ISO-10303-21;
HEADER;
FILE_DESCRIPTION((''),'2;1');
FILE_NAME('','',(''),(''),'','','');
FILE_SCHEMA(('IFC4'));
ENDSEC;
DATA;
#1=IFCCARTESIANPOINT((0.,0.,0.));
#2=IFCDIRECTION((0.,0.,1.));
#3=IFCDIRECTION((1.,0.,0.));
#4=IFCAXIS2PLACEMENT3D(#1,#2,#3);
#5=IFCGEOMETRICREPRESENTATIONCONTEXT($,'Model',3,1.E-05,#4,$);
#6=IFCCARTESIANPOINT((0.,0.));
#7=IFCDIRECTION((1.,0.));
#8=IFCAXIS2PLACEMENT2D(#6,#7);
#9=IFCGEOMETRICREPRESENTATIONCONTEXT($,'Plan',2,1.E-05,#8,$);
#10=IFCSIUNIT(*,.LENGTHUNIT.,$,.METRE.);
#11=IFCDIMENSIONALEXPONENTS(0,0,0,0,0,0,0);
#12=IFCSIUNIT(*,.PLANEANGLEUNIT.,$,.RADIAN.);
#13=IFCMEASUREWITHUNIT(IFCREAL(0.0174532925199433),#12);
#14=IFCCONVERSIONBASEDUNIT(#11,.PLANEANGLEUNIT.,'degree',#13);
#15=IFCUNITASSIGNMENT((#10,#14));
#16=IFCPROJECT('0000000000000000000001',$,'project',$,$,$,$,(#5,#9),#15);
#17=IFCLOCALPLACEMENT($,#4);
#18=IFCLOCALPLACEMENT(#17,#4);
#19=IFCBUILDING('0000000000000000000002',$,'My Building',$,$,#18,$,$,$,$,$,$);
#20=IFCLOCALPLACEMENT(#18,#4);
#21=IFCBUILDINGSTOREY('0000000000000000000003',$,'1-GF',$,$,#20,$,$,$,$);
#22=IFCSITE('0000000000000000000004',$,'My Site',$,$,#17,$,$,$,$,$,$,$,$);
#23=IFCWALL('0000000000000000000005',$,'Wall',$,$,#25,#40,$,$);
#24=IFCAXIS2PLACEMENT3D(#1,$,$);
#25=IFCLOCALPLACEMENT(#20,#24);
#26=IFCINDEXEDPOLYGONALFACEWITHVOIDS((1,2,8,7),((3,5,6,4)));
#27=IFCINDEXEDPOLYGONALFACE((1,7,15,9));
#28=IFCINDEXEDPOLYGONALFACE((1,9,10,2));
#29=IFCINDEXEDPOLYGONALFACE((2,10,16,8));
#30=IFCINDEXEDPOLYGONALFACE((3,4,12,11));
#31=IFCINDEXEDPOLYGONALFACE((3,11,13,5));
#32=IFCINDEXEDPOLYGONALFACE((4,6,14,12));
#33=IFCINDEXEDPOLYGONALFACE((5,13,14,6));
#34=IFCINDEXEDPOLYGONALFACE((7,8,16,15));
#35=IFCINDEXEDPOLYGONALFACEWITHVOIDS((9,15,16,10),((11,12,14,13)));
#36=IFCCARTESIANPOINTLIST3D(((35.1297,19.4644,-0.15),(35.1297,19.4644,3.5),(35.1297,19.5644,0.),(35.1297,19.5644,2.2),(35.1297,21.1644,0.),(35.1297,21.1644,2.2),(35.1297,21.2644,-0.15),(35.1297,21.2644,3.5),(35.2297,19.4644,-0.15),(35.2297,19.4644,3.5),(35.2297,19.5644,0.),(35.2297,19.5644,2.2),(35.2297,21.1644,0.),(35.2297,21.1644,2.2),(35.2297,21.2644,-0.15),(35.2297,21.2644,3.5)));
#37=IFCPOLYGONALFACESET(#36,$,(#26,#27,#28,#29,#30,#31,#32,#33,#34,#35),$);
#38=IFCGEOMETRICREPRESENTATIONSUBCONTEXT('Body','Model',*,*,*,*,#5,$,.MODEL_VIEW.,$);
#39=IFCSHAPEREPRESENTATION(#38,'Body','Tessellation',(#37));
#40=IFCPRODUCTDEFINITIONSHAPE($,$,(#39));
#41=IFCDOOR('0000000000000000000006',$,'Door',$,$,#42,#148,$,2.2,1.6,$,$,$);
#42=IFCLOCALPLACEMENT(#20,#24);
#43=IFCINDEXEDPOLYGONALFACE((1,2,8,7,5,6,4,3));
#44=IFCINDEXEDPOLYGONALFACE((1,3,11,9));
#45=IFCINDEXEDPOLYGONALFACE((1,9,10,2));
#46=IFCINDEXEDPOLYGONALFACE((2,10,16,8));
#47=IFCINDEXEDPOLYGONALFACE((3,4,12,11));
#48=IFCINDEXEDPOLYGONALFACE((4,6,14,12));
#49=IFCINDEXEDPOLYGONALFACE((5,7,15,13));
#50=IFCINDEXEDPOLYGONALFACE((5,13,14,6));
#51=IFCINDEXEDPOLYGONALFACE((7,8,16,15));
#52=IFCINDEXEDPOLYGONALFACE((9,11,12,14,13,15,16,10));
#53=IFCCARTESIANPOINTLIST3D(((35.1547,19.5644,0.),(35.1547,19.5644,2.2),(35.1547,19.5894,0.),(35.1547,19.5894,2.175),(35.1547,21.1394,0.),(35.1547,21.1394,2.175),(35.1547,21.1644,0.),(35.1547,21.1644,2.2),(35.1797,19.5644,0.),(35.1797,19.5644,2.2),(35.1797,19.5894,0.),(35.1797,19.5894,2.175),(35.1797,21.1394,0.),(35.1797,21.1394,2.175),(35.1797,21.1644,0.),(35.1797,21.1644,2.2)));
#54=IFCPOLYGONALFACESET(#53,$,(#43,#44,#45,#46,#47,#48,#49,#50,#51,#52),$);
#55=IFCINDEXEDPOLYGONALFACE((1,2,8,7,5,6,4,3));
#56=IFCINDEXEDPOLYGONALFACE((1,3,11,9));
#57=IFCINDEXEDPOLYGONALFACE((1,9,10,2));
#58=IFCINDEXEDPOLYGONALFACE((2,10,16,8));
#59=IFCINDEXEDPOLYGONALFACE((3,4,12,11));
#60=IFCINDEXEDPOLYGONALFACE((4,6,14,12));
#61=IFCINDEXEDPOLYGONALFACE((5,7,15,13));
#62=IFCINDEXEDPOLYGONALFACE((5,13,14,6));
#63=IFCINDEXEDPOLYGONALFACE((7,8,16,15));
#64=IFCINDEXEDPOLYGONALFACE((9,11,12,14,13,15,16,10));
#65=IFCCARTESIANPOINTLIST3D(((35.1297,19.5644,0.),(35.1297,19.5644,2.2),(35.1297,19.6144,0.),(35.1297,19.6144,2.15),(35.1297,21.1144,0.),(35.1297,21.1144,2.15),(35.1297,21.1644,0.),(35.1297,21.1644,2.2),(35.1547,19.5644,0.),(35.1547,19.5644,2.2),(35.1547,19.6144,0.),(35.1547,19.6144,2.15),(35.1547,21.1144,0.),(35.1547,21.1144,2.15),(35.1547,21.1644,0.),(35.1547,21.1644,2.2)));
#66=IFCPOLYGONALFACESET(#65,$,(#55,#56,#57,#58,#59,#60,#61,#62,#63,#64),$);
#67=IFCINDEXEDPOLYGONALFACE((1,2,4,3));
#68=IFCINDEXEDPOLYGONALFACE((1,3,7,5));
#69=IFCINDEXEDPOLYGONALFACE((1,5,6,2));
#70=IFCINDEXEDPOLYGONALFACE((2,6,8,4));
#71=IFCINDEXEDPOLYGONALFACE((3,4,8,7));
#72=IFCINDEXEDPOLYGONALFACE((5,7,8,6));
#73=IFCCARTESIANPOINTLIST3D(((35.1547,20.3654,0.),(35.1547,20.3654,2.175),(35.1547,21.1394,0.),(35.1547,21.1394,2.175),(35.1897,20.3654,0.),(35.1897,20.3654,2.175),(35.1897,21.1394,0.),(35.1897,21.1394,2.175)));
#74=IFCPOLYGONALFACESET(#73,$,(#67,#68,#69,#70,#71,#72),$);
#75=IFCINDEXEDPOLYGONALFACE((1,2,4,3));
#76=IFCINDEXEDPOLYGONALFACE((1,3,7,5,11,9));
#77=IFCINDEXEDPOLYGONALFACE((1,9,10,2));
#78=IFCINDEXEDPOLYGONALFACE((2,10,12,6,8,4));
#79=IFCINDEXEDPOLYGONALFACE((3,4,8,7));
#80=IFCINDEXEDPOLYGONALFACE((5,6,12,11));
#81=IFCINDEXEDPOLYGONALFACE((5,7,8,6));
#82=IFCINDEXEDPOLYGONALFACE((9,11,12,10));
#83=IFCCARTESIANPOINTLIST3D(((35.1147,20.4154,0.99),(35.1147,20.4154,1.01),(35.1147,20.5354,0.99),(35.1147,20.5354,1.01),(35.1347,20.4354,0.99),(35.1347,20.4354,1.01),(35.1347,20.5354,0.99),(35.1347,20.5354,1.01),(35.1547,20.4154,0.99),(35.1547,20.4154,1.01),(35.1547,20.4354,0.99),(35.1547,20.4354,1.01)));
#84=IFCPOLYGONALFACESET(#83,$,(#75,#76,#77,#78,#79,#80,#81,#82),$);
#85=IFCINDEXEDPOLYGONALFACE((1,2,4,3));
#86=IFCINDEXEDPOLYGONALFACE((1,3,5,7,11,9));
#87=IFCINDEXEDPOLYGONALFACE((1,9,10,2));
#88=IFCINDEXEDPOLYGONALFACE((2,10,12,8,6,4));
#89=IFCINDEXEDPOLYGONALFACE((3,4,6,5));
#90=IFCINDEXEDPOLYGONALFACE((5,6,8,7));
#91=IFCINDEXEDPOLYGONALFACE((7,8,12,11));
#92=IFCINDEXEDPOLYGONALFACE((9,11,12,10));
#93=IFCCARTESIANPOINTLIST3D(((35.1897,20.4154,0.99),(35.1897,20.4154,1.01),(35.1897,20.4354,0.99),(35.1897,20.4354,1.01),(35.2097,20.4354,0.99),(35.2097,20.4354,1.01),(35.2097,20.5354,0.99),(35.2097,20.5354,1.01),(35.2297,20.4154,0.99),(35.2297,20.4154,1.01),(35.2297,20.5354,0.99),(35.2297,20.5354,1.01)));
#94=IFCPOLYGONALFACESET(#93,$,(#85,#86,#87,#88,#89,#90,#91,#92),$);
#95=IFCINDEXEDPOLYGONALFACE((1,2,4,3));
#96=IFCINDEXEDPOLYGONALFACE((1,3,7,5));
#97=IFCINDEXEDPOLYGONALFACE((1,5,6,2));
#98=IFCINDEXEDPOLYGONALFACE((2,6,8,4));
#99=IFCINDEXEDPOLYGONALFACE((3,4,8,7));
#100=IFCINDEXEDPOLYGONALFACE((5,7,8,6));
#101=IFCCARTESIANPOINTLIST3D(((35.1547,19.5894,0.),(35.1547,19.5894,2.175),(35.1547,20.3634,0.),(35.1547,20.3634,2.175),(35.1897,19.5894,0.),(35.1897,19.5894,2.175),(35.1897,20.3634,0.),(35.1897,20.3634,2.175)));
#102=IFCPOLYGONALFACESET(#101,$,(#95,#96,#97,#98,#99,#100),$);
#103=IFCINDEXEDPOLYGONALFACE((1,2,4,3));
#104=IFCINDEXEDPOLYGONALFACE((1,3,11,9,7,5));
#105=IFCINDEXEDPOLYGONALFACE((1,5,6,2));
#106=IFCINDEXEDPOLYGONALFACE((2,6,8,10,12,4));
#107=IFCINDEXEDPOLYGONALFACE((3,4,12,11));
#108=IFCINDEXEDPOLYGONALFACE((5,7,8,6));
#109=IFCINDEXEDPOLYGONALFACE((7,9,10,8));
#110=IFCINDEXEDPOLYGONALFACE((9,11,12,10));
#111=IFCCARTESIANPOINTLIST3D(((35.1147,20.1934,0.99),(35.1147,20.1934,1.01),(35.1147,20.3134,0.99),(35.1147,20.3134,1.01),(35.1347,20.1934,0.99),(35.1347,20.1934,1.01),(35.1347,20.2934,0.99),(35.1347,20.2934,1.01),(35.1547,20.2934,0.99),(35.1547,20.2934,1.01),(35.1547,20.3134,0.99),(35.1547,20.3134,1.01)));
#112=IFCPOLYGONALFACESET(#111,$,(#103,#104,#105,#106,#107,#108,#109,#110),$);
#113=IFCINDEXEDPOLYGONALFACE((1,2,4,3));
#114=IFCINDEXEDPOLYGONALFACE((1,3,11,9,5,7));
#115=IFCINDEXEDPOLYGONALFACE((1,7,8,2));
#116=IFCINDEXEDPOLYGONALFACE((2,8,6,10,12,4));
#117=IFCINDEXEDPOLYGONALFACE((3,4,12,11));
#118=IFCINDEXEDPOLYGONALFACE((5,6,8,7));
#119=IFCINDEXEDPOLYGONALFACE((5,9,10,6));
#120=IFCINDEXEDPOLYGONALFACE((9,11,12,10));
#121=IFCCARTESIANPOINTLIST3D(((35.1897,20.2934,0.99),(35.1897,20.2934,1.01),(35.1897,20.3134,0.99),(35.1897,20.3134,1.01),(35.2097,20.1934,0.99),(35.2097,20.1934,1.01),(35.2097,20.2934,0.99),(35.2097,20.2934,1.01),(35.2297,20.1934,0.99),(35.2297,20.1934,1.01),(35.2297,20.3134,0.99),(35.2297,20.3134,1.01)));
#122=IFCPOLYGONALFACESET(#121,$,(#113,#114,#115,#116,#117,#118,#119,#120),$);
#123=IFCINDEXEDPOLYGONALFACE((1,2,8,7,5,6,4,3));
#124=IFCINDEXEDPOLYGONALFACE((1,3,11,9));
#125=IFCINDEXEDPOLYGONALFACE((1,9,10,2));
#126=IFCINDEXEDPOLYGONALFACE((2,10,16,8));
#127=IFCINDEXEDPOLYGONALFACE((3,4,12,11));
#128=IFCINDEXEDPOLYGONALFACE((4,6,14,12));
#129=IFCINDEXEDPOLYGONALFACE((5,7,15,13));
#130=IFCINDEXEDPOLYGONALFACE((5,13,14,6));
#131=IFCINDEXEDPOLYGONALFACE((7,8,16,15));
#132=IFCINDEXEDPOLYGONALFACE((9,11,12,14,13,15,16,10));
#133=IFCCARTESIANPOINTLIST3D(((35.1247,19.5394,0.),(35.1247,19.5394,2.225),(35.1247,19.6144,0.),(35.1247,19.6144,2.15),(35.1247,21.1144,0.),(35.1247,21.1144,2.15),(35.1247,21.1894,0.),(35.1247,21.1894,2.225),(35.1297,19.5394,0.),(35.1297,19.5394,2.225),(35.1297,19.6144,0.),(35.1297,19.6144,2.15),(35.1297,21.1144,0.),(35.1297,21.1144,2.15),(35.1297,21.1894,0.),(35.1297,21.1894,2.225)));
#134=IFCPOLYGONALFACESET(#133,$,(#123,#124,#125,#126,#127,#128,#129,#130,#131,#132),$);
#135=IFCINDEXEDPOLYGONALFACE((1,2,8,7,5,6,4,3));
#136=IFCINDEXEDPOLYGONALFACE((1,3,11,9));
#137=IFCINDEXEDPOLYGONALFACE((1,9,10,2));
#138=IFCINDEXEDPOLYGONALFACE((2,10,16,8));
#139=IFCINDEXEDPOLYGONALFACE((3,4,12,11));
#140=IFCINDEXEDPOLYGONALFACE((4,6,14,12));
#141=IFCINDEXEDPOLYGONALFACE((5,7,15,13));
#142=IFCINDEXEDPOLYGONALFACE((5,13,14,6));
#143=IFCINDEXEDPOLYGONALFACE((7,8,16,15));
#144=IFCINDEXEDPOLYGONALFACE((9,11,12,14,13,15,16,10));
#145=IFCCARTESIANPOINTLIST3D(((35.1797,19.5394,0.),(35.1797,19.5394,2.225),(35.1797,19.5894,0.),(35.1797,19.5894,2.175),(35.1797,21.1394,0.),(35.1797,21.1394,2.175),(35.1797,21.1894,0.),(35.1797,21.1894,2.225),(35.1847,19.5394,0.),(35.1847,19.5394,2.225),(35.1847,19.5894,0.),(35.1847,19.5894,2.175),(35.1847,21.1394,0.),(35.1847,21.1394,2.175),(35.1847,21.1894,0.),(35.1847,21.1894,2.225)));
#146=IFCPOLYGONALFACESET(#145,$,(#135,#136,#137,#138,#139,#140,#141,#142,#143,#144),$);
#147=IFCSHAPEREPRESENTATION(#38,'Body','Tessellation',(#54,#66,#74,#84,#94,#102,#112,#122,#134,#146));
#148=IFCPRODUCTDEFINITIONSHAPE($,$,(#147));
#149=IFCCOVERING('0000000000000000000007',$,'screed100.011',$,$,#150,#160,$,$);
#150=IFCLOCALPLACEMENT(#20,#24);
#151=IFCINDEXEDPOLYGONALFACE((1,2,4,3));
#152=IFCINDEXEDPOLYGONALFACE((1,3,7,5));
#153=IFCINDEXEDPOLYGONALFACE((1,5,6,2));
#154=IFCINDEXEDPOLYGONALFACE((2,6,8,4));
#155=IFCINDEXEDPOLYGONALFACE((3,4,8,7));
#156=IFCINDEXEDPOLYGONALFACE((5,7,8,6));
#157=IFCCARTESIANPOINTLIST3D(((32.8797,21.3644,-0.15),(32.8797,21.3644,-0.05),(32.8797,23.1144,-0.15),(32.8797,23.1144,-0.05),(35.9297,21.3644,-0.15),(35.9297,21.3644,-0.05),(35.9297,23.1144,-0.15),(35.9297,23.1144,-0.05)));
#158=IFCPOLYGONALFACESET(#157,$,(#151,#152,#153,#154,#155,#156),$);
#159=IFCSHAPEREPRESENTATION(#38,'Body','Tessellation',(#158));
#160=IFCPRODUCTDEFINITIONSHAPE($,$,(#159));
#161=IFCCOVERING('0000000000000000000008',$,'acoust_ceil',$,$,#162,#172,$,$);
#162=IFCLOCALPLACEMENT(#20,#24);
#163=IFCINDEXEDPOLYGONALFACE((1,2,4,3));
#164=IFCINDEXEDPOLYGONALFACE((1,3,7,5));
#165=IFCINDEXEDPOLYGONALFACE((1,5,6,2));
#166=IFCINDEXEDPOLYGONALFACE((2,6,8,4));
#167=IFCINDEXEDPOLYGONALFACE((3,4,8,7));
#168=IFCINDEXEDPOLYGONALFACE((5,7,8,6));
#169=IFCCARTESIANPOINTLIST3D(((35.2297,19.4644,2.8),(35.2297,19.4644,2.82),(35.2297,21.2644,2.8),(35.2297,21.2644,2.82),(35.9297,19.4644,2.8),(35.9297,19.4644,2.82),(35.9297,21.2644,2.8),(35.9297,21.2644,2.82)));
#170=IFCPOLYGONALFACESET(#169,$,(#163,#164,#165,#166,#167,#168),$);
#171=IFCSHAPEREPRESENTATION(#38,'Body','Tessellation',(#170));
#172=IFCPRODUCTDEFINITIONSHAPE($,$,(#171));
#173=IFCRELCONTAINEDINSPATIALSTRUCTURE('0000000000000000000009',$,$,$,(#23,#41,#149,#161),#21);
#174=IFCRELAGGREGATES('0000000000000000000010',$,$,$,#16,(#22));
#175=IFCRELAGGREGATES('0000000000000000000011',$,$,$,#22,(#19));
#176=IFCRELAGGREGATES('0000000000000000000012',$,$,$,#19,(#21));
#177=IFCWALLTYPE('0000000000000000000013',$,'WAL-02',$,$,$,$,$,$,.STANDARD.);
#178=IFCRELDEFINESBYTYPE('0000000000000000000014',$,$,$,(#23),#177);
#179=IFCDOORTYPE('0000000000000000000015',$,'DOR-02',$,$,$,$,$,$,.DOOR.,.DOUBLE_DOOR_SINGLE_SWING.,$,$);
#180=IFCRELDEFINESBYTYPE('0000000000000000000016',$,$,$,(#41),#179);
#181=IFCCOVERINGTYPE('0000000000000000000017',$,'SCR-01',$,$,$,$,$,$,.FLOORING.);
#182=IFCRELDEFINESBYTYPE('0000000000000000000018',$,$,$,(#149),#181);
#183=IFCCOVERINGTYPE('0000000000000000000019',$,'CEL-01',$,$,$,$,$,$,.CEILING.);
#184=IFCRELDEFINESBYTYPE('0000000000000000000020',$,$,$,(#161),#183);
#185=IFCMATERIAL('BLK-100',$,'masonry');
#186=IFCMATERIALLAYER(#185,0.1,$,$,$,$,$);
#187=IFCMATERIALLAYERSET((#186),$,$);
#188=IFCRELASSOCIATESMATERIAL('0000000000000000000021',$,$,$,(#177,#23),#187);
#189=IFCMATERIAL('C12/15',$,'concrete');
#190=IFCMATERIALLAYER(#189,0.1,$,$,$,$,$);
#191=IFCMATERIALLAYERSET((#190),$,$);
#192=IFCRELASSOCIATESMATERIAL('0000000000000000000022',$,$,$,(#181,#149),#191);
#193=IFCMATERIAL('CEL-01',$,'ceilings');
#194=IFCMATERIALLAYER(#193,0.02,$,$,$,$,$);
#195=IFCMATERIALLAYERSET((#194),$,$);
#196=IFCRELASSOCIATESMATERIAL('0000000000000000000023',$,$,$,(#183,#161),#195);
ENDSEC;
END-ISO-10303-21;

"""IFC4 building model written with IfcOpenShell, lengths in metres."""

from ifc_helpers import new_model, entity, si_unit, converted_unit, frame, origin_with_axes, origin_2d_with_axis, place, context, subcontext, project, spatial, line, indexed_curve, outline, extrude, shape, source, transform, mapped, material, layer, layer_set, layer_usage, type_object, type_shapes, element, fill, save


model = new_model("IFC4")

# Units and contexts
model_context = context("Model", 3, precision=1e-05, world=origin_with_axes())
plan_context = context("Plan", 2, precision=1e-05, world=origin_2d_with_axis())
body_context_1 = subcontext(model_context, "Body", "Model", "MODEL_VIEW")
body_context_2 = subcontext(plan_context, "Body", "Plan", "PLAN_VIEW")
ifc_project = project(units=[si_unit("LENGTHUNIT", "METRE"), converted_unit("PLANEANGLEUNIT", "degree", entity("IfcReal", 0.0174532925199433), si_unit("PLANEANGLEUNIT", "RADIAN"), dimensions=[0, 0, 0, 0, 0, 0, 0])], contexts=[model_context, plan_context])

# Site, building, storey
site_placement = place(None, origin_with_axes())
site = spatial("IfcSite", under=ifc_project, at=site_placement, Name="My Site")
building_placement = place(site_placement, origin_with_axes())
building = spatial("IfcBuilding", under=site, at=building_placement, Name="My Building")
storey_placement = place(building_placement, origin_with_axes())
storey = spatial("IfcBuildingStorey", under=building, at=storey_placement, Name="1-GF")

# Shared definitions
ifc_material_1 = material(Name="BLK-100", Category="masonry")
ifc_layer_1 = layer(ifc_material_1, 0.1)
ifc_layer_set_1 = layer_set([ifc_layer_1])
wall_type = type_object("IfcWallType", Name="WAL-02", PredefinedType="STANDARD", material=ifc_layer_set_1)

# Wall, opening, door
ifc_layer_usage_1 = layer_usage(ifc_layer_set_1, "AXIS2", "POSITIVE", 0.0)
wall_1_placement = place(storey_placement, frame((35.1297, 21.2644, -0.15), z_axis=(0.0, 0.0, 1.0), x_axis=(0.0, -1.0, 0.0)))
wall_1 = element("IfcWall", 1, at=wall_1_placement, inside=storey, type_object=wall_type, material=ifc_layer_usage_1, Name="Wall", context=body_context_1, shape_type="SweptSolid", body=[
    extrude(outline(indexed_curve([(0.0, 0.0), (0.0, 0.1), (1.8, 0.1), (1.8, 0.0), (0.0, 0.0)], self_intersect=False)), origin_with_axes(), (0.0, 0.0, 1.0), 3.65),
])
shared_shape_1 = source(origin_with_axes(), body_context_1, "Body", "SweptSolid", [
    extrude(outline(indexed_curve([(0.0, 0.0), (1.6, 0.0), (1.6, 2.2), (0.0, 2.2)], segments=[line(1, 2, 3, 4, 1)])), frame((0.0, -0.1, 0.0), z_axis=(0.0, -1.0, 0.0), x_axis=(1.0, 0.0, 0.0)), (0.0, 0.0, -1.0), 0.4),
])
opening_1_placement = place(wall_1_placement, frame((0.1, 0.0, 0.15), z_axis=(0.0, 0.0, 1.0), x_axis=(1.0, 0.0, 0.0)))
opening_1 = element("IfcOpeningElement", 2, at=opening_1_placement, cuts=wall_1, PredefinedType="OPENING", context=body_context_1, shape_type="MappedRepresentation", body=[
    mapped(shared_shape_1, transform((0.0, 0.0, 0.0), x_axis=(1.0, 0.0, 0.0), y_axis=(0.0, 1.0, 0.0), z_axis=(0.0, 0.0, 1.0), scale=1.0)),
])
door_type_1 = type_object("IfcDoorType", Name="DOR-02", OperationType="DOUBLE_DOOR_SINGLE_SWING", PredefinedType="DOOR")
shared_shape_2 = source(origin_with_axes(), body_context_1, "Body", "SweptSolid", [
    extrude(outline(indexed_curve([(0.0, 0.0), (0.0, 2.2), (1.6, 2.2), (1.6, 0.0), (1.575, 0.0), (1.575, 2.175), (0.025, 2.175), (0.025, 0.0)], segments=[line(1, 2, 3, 4, 5, 6, 7, 8, 1)])), frame((0.0, 0.025, 0.0), z_axis=(0.0, -1.0, 0.0), x_axis=(1.0, 0.0, 0.0)), (0.0, 0.0, -1.0), 0.025),
    extrude(outline(indexed_curve([(0.0, 0.0), (0.0, 2.2), (1.6, 2.2), (1.6, 0.0), (1.55, 0.0), (1.55, 2.15), (0.05, 2.15), (0.05, 0.0)], segments=[line(1, 2, 3, 4, 5, 6, 7, 8, 1)])), frame((0.0, 0.0, 0.0), z_axis=(0.0, -1.0, 0.0), x_axis=(1.0, 0.0, 0.0)), (0.0, 0.0, -1.0), 0.025),
    extrude(outline(indexed_curve([(0.0, 0.0), (0.774, 0.0), (0.774, 0.035), (0.0, 0.035)], segments=[line(1, 2, 3, 4, 1)])), frame((0.025, 0.025, 0.0), z_axis=(0.0, 0.0, 1.0), x_axis=(1.0, 0.0, 0.0)), (0.0, 0.0, 1.0), 2.175),
    extrude(outline(indexed_curve([(0.0, 0.0), (0.0, -0.04), (-0.12, -0.04), (-0.12, -0.02), (-0.02, -0.02), (-0.02, 0.0)], segments=[line(1, 2, 3, 4, 5, 6, 1)])), frame((0.749, 0.025, 0.99), z_axis=(0.0, 0.0, 1.0), x_axis=(1.0, 0.0, 0.0)), (0.0, 0.0, 1.0), 0.02),
    extrude(outline(indexed_curve([(0.0, 0.0), (0.0, 0.04), (-0.12, 0.04), (-0.12, 0.02), (-0.02, 0.02), (-0.02, 0.0)], segments=[line(1, 2, 3, 4, 5, 6, 1)])), frame((0.749, 0.06, 0.99), z_axis=(0.0, 0.0, 1.0), x_axis=(1.0, 0.0, 0.0)), (0.0, 0.0, 1.0), 0.02),
    extrude(outline(indexed_curve([(0.0, 0.0), (-0.774, 0.0), (-0.774, 0.035), (0.0, 0.035)], segments=[line(1, 2, 3, 4, 1)])), frame((1.575, 0.025, 0.0), z_axis=(0.0, 0.0, 1.0), x_axis=(1.0, 0.0, 0.0)), (0.0, 0.0, 1.0), 2.175),
    extrude(outline(indexed_curve([(0.0, 0.0), (0.0, -0.04), (0.12, -0.04), (0.12, -0.02), (0.02, -0.02), (0.02, 0.0)], segments=[line(1, 2, 3, 4, 5, 6, 1)])), frame((0.851, 0.025, 0.99), z_axis=(0.0, 0.0, 1.0), x_axis=(1.0, 0.0, 0.0)), (0.0, 0.0, 1.0), 0.02),
    extrude(outline(indexed_curve([(0.0, 0.0), (0.0, 0.04), (0.12, 0.04), (0.12, 0.02), (0.02, 0.02), (0.02, 0.0)], segments=[line(1, 2, 3, 4, 5, 6, 1)])), frame((0.851, 0.06, 0.99), z_axis=(0.0, 0.0, 1.0), x_axis=(1.0, 0.0, 0.0)), (0.0, 0.0, 1.0), 0.02),
    extrude(outline(indexed_curve([(0.0, 0.0), (0.0, 2.225), (1.65, 2.225), (1.65, 0.0), (1.575, 0.0), (1.575, 2.15), (0.075, 2.15), (0.075, 0.0)], segments=[line(1, 2, 3, 4, 5, 6, 7, 8, 1)])), frame((-0.025, -0.005, 0.0), z_axis=(0.0, -1.0, 0.0), x_axis=(1.0, 0.0, 0.0)), (0.0, 0.0, -1.0), 0.005),
    extrude(outline(indexed_curve([(0.0, 0.0), (0.0, 2.225), (1.65, 2.225), (1.65, 0.0), (1.6, 0.0), (1.6, 2.175), (0.05, 2.175), (0.05, 0.0)], segments=[line(1, 2, 3, 4, 5, 6, 7, 8, 1)])), frame((-0.025, 0.05, 0.0), z_axis=(0.0, -1.0, 0.0), x_axis=(1.0, 0.0, 0.0)), (0.0, 0.0, -1.0), 0.005),
])
shared_shape_3 = source(origin_with_axes(), body_context_2, "Body", "Curve2D", [
    entity("IfcIndexedPolyCurve", entity("IfcCartesianPointList2D", [[0.0, 0.0], [0.0, 0.05], [0.025, 0.05], [0.025, 0.025], [0.05, 0.025], [0.05, 0.0]]), [entity("IfcLineIndex", [1, 2, 3, 4, 5, 6, 1])]),
    entity("IfcIndexedPolyCurve", entity("IfcCartesianPointList2D", [[1.6, 0.0], [1.6, 0.05], [1.575, 0.05], [1.575, 0.025], [1.55, 0.025], [1.55, 0.0]]), [entity("IfcLineIndex", [1, 2, 3, 4, 5, 6, 1])]),
    entity("IfcTrimmedCurve", entity("IfcEllipse", entity("IfcAxis2Placement2D", entity("IfcCartesianPoint", [0.06, 0.05]), entity("IfcDirection", [1.0, 0.0])), 0.74, 0.775), [entity("IfcCartesianPoint", [0.8, 0.05])], [entity("IfcCartesianPoint", [0.06, 0.825])], True, "CARTESIAN"),
    entity("IfcIndexedPolyCurve", entity("IfcCartesianPointList2D", [[0.025, 0.05], [0.06, 0.05], [0.06, 0.825], [0.025, 0.825]]), [entity("IfcLineIndex", [1, 2, 3, 4, 1])]),
    entity("IfcTrimmedCurve", entity("IfcEllipse", entity("IfcAxis2Placement2D", entity("IfcCartesianPoint", [1.54, 0.05]), entity("IfcDirection", [1.0, 0.0])), 0.74, 0.775), [entity("IfcCartesianPoint", [1.54, 0.825])], [entity("IfcCartesianPoint", [0.8, 0.05])], True, "CARTESIAN"),
    entity("IfcIndexedPolyCurve", entity("IfcCartesianPointList2D", [[1.575, 0.05], [1.54, 0.05], [1.54, 0.825], [1.575, 0.825]]), [entity("IfcLineIndex", [1, 2, 3, 4, 1])]),
])
type_shapes(door_type_1, [shared_shape_2, shared_shape_3])
door_1_placement = place(opening_1_placement, frame((0.0, 0.0, 0.0), z_axis=(0.0, 0.0, 1.0), x_axis=(1.0, 0.0, 0.0)))
door_1 = element("IfcDoor", 3, at=door_1_placement, inside=storey, type_object=door_type_1, Name="Door", OverallHeight=2.2, OverallWidth=1.6, shapes=[
    shape(body_context_1, "Body", "MappedRepresentation", [mapped(shared_shape_2, transform((0.0, 0.0, 0.0), x_axis=(1.0, 0.0, 0.0), y_axis=(0.0, 1.0, 0.0), z_axis=(0.0, 0.0, 1.0), scale=1.0))]),
    shape(body_context_2, "Body", "MappedRepresentation", [mapped(shared_shape_3, transform((0.0, 0.0, 0.0), x_axis=(1.0, 0.0, 0.0), y_axis=(0.0, 1.0, 0.0), z_axis=(0.0, 0.0, 1.0), scale=1.0))]),
])
fill(opening_1, door_1)

# Coverings
ifc_material_2 = material(Name="C12/15", Category="concrete")
ifc_layer_2 = layer(ifc_material_2, 0.1)
ifc_layer_set_2 = layer_set([ifc_layer_2])
covering_type_1 = type_object("IfcCoveringType", Name="SCR-01", PredefinedType="FLOORING", material=ifc_layer_set_2)
ifc_layer_usage_2 = layer_usage(ifc_layer_set_2, "AXIS3", "POSITIVE", 0.0)
covering_1_placement = place(storey_placement, frame((32.8797, 21.3644, -0.15), z_axis=(0.0, 0.0, 1.0), x_axis=(1.0, 0.0, 0.0)))
element("IfcCovering", 4, at=covering_1_placement, inside=storey, type_object=covering_type_1, material=ifc_layer_usage_2, Name="screed100.011", context=body_context_1, shape_type="SweptSolid", body=[
    extrude(outline(indexed_curve([(0.0, 0.0), (3.05, 0.0), (3.05, 1.75), (0.0, 1.75)], segments=[line(4, 1), line(1, 2), line(2, 3), line(3, 4)], self_intersect=False)), None, (0.0, 0.0, 1.0), 0.1),
])
ifc_material_3 = material(Name="CEL-01", Category="ceilings")
ifc_layer_3 = layer(ifc_material_3, 0.02)
ifc_layer_set_3 = layer_set([ifc_layer_3])
covering_type_2 = type_object("IfcCoveringType", Name="CEL-01", PredefinedType="CEILING", material=ifc_layer_set_3)
ifc_layer_usage_3 = layer_usage(ifc_layer_set_3, "AXIS3", "POSITIVE", 0.0)
covering_2_placement = place(storey_placement, frame((35.2297, 19.4644, 2.8), z_axis=(0.0, 0.0, 1.0), x_axis=(1.0, 0.0, 0.0)))
element("IfcCovering", 5, at=covering_2_placement, inside=storey, type_object=covering_type_2, material=ifc_layer_usage_3, Name="acoust_ceil", context=body_context_1, shape_type="SweptSolid", body=[
    extrude(outline(indexed_curve([(0.7, 1.8), (0.7, 0.0), (0.0, 0.0), (0.0, 1.8)], segments=[line(4, 1), line(1, 2), line(2, 3), line(3, 4)], self_intersect=False)), None, (0.0, 0.0, 1.0), 0.02),
])

save(model, "model.ifc")
